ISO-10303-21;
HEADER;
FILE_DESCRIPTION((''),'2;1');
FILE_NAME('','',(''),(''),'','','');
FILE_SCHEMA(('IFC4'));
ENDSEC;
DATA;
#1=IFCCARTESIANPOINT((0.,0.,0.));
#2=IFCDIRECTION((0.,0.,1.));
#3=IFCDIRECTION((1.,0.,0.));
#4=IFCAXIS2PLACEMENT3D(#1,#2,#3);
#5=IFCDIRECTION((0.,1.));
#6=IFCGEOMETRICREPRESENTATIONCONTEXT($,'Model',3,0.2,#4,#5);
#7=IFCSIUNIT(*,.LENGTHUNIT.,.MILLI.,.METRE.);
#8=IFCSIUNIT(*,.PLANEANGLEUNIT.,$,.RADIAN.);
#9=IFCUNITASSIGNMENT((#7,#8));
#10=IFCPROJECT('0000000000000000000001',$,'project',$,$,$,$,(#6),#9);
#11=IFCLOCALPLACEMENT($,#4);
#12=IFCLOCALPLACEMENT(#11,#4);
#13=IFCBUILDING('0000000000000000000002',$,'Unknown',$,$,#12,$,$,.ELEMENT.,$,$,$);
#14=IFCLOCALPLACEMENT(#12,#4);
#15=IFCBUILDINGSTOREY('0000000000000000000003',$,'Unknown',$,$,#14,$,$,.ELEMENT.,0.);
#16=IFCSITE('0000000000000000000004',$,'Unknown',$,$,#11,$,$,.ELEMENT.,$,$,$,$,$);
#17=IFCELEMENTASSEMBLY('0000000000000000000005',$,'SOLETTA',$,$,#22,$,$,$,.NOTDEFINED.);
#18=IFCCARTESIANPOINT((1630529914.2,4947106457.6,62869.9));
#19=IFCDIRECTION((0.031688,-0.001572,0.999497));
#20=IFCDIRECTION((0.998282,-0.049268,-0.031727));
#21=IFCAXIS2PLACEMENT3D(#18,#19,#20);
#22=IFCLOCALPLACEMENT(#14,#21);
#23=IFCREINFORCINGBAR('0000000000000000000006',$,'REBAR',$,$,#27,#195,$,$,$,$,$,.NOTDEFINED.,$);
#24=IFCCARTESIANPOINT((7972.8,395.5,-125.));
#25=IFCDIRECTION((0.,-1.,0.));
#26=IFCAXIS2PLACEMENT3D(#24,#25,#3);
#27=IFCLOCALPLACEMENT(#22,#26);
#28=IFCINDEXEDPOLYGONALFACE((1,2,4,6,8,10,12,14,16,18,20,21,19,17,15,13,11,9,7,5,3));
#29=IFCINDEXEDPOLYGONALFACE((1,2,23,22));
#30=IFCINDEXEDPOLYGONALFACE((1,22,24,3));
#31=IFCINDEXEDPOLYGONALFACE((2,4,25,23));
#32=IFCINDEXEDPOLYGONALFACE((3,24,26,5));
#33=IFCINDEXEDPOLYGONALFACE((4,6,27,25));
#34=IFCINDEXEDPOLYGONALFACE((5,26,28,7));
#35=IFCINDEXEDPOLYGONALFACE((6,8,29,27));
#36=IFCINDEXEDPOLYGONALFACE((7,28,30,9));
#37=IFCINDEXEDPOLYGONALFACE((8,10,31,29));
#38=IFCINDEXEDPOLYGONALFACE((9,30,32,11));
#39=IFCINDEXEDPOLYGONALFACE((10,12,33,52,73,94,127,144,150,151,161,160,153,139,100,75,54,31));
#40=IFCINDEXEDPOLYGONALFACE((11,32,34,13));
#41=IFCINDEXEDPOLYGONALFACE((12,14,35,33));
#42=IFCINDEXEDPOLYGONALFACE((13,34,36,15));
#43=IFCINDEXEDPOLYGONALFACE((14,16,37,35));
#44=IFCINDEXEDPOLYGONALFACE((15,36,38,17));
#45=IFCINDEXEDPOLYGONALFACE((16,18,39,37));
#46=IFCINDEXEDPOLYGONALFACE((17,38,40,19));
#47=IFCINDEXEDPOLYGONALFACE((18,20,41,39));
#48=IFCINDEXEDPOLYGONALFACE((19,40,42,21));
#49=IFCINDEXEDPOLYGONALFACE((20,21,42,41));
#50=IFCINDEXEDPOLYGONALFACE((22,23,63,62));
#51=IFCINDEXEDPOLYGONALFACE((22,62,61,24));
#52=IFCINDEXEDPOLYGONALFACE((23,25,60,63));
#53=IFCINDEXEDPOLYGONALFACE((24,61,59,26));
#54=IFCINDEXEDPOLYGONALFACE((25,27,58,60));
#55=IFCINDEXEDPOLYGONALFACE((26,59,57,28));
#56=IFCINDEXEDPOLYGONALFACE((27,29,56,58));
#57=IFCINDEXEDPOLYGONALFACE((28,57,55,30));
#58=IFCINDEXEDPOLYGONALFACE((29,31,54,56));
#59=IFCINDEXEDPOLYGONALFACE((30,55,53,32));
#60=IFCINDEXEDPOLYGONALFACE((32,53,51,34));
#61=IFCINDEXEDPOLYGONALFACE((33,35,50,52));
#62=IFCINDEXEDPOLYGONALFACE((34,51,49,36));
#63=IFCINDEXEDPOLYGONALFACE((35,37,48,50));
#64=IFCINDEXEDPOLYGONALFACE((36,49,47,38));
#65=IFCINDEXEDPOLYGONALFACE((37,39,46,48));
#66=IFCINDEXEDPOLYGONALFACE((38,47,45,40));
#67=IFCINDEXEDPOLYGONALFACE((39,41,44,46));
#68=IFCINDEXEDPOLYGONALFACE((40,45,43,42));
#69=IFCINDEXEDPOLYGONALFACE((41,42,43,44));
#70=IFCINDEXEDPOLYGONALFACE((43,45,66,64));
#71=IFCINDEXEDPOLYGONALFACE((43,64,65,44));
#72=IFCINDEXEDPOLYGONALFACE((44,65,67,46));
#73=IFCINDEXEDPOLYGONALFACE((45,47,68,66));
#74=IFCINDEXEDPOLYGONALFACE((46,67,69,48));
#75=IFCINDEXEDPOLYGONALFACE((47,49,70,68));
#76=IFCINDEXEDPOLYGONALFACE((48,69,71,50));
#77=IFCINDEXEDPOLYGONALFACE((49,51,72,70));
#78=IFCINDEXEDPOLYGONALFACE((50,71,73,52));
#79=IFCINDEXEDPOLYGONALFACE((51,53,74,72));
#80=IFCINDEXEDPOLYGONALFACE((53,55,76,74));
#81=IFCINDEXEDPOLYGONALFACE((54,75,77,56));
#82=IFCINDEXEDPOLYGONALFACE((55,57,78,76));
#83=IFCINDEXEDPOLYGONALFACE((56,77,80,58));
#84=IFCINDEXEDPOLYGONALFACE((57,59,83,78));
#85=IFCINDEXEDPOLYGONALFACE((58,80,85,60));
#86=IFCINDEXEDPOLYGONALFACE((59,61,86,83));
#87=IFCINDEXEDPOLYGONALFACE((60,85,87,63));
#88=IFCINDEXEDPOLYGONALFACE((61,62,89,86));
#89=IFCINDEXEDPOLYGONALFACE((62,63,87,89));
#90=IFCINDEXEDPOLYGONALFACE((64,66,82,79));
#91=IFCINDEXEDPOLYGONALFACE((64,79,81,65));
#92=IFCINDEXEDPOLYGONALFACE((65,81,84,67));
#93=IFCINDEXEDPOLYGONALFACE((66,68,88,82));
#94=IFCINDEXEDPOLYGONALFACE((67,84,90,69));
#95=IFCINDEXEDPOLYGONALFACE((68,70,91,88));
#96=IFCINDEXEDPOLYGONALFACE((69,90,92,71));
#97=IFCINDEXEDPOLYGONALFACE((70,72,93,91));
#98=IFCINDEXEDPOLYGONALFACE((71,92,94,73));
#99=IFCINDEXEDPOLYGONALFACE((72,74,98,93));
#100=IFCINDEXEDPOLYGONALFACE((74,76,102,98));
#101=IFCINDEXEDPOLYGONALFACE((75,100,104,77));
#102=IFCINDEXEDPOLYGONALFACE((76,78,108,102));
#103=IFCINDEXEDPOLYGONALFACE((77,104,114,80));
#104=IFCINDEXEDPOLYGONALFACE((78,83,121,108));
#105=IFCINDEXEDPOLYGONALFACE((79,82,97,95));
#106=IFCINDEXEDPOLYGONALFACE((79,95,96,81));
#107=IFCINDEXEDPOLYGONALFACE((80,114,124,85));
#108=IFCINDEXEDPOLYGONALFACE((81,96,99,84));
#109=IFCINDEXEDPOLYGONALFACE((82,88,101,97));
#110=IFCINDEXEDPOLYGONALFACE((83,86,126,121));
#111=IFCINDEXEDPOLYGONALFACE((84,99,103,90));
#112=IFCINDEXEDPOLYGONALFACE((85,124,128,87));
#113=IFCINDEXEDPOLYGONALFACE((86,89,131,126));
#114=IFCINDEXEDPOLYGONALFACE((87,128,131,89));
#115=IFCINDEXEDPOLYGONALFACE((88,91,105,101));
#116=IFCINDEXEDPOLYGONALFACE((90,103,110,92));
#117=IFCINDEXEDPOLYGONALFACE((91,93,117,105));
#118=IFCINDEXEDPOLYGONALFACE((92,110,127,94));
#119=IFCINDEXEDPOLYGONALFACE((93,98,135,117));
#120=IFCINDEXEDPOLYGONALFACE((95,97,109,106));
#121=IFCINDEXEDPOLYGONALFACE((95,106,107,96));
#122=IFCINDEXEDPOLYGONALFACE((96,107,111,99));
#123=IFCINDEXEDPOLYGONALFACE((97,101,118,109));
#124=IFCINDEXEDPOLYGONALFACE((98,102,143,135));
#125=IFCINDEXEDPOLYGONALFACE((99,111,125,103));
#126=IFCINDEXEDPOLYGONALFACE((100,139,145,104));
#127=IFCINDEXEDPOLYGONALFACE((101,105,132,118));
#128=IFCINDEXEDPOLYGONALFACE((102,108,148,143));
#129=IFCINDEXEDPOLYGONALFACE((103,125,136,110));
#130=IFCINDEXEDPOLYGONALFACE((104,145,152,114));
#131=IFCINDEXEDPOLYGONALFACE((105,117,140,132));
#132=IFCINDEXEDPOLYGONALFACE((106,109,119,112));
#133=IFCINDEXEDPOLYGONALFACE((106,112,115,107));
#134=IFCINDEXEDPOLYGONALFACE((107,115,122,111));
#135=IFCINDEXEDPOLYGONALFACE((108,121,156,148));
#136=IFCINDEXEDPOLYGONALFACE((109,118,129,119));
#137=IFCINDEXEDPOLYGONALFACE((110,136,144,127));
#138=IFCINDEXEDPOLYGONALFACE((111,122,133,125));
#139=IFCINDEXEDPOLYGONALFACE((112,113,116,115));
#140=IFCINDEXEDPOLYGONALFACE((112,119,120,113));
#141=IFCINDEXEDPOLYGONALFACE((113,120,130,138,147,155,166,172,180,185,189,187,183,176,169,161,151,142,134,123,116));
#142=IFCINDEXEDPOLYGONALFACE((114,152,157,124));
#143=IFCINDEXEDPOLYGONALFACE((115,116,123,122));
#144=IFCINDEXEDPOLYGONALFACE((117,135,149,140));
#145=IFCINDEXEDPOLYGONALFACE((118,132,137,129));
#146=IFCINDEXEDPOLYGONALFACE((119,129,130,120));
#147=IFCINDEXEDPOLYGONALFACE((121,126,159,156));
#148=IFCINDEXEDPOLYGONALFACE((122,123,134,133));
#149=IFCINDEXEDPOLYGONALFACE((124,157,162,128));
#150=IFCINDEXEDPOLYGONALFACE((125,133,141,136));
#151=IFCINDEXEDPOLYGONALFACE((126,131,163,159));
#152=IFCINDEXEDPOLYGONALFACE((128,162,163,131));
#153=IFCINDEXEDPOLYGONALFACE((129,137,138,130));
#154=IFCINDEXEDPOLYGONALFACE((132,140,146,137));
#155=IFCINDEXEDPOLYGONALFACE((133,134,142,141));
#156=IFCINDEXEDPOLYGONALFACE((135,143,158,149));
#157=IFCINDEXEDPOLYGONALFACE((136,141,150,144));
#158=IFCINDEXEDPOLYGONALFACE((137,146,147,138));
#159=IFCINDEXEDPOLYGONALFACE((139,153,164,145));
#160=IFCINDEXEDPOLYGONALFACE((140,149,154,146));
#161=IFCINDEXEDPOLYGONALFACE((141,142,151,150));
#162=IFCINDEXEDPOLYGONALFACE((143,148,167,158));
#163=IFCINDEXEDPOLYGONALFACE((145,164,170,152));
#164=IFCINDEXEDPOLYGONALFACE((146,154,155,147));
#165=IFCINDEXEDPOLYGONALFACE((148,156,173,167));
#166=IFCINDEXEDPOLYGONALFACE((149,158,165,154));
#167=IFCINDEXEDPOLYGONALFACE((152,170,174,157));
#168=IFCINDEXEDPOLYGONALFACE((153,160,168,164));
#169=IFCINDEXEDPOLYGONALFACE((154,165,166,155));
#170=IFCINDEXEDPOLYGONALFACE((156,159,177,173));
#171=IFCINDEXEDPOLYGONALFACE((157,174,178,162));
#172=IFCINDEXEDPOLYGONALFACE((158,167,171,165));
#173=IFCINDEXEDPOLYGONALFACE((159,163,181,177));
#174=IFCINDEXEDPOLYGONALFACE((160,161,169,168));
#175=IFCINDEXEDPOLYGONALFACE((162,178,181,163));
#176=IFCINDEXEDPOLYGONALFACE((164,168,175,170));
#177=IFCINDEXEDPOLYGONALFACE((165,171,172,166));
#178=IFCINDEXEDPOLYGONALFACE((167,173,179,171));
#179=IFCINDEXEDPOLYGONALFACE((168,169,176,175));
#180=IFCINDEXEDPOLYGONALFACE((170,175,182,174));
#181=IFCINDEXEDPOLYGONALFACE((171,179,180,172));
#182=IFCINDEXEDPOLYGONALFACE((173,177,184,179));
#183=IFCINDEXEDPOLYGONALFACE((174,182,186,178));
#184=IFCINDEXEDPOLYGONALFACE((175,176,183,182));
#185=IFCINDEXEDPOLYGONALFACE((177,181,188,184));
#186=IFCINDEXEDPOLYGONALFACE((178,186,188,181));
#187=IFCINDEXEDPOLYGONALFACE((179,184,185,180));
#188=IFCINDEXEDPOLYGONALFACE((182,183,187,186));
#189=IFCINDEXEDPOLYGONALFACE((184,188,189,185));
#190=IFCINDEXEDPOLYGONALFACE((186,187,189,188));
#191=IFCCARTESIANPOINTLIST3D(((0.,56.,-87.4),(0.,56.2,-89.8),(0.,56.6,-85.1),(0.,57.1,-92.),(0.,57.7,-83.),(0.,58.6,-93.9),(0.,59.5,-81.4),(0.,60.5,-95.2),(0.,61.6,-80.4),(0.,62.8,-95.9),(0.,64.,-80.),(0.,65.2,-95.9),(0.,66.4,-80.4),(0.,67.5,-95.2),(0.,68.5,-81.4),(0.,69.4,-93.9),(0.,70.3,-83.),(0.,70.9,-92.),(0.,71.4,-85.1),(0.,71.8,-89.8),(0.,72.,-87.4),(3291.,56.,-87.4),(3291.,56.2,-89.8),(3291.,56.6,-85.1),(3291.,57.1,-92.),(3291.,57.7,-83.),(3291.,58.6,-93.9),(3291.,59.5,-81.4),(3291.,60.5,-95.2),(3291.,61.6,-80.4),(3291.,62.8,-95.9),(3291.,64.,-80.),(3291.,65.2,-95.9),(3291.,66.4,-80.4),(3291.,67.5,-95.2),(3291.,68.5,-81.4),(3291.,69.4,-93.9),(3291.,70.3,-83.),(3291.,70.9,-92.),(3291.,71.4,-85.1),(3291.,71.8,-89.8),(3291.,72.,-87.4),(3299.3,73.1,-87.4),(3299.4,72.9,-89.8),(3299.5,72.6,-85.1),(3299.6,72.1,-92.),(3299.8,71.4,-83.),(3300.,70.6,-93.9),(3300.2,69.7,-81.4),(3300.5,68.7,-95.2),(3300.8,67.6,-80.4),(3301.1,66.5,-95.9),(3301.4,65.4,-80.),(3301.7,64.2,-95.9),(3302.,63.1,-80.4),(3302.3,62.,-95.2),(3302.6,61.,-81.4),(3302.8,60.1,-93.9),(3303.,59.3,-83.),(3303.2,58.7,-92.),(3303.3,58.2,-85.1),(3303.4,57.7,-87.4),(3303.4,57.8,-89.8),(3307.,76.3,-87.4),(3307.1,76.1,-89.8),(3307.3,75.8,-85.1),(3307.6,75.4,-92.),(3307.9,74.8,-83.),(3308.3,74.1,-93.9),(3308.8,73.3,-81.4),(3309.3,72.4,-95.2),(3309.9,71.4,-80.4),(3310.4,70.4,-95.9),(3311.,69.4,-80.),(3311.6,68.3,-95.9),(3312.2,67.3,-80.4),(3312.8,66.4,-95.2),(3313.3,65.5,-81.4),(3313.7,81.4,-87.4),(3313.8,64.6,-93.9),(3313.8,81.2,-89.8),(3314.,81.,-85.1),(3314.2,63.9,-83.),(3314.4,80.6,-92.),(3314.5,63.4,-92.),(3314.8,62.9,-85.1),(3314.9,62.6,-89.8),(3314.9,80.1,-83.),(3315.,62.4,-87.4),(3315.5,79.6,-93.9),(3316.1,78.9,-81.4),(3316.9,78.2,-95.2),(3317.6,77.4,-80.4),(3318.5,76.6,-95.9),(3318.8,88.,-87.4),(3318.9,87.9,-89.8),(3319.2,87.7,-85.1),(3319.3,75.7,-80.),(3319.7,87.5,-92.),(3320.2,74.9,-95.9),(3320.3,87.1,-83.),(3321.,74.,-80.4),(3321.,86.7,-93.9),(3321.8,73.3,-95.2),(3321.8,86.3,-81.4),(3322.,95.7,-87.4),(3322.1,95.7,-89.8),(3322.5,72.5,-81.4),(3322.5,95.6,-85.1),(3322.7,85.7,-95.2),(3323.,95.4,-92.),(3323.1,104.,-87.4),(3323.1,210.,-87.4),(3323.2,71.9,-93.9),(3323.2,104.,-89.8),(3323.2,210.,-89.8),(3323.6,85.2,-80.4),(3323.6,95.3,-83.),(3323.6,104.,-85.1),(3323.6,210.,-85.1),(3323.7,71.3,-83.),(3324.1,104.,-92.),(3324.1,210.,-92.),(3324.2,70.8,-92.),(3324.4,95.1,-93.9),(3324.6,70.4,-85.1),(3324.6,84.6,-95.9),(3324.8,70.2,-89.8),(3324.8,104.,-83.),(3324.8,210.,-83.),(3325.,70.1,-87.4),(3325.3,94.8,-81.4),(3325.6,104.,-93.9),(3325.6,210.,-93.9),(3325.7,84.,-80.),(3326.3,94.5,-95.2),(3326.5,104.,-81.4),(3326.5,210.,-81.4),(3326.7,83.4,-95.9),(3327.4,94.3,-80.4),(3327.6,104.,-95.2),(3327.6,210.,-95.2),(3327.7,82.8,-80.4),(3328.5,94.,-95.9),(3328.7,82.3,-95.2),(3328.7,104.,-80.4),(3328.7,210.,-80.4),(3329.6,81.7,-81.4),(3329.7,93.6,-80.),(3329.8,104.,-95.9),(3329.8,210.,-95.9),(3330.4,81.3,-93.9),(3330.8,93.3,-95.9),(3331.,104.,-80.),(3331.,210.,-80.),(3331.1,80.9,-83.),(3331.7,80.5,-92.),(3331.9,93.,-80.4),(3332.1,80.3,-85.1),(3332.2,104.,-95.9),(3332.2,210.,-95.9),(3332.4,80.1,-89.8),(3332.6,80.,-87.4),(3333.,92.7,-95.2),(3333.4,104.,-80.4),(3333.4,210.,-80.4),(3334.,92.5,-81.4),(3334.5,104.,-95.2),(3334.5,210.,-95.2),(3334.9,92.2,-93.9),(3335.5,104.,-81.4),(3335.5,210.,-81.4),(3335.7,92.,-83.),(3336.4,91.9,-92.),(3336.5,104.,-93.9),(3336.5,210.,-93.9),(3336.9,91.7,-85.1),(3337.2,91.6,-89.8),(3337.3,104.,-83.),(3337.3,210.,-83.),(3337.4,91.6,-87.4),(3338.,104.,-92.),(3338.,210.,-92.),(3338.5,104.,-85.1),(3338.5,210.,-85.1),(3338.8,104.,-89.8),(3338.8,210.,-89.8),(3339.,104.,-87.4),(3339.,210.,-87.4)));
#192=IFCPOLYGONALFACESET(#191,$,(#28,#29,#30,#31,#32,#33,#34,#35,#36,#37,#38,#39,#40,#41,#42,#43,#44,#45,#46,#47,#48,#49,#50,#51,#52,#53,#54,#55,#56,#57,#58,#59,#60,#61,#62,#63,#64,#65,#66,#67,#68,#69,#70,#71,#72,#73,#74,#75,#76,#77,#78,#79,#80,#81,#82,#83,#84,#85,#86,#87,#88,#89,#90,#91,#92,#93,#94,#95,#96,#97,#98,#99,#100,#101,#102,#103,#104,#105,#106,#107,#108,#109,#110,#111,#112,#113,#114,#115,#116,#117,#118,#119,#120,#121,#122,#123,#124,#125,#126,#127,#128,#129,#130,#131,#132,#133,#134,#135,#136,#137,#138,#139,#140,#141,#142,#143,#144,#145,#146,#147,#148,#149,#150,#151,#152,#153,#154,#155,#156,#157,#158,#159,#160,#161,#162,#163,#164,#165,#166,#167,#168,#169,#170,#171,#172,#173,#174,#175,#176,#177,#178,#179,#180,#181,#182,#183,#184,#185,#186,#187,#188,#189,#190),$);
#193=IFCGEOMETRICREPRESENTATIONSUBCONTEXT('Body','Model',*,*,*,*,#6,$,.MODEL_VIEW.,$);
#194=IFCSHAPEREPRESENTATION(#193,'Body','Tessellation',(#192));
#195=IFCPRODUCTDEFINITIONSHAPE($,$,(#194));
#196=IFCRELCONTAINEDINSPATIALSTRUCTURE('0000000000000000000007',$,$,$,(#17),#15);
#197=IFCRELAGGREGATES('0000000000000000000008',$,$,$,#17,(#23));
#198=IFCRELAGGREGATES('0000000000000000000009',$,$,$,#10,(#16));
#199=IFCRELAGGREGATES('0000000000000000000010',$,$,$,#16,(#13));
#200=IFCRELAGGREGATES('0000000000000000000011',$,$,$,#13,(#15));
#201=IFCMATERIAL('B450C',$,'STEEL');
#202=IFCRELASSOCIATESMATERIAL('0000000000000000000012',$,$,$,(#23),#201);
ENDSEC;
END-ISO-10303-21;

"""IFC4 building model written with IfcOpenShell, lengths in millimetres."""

from ifc_helpers import new_model, entity, si_unit, direction, frame, origin_with_axes, place, context, subcontext, project, spatial, material, element, aggregate, save


model = new_model("IFC4")

# Units and contexts
model_context = context("Model", 3, precision=0.2, world=origin_with_axes(), true_north=direction((0.0, 1.0)))
body_context = subcontext(model_context, "Body", "Model", "MODEL_VIEW")
ifc_project = project(units=[si_unit("LENGTHUNIT", "METRE", prefix="MILLI"), si_unit("PLANEANGLEUNIT", "RADIAN")], contexts=[model_context])

# Site, building, storey
site_placement = place(None, origin_with_axes())
site = spatial("IfcSite", under=ifc_project, at=site_placement, Name="Unknown", CompositionType="ELEMENT")
building_placement = place(site_placement, origin_with_axes())
building = spatial("IfcBuilding", under=site, at=building_placement, Name="Unknown", CompositionType="ELEMENT")
storey_placement = place(building_placement, origin_with_axes())
storey = spatial("IfcBuildingStorey", under=building, at=storey_placement, Name="Unknown", CompositionType="ELEMENT", Elevation=0.0)

# Element assembly, reinforcing bar
ifc_material = material(Name="B450C", Category="STEEL")
assembly_1_placement = place(storey_placement, frame((1630529914.2, 4947106457.6, 62869.9), z_axis=(0.031688, -0.001572, 0.999497), x_axis=(0.998282, -0.049268, -0.031727)))
assembly_1 = element("IfcElementAssembly", 1, at=assembly_1_placement, inside=storey, Name="SOLETTA", PredefinedType="NOTDEFINED")
reinforcing_bar_1_placement = place(assembly_1_placement, frame((7972.8, 395.5, -125.0), z_axis=(0.0, -1.0, 0.0), x_axis=(1.0, 0.0, 0.0)))
reinforcing_bar_1 = element("IfcReinforcingBar", 2, at=reinforcing_bar_1_placement, material=ifc_material, Name="REBAR", PredefinedType="NOTDEFINED", context=body_context, shape_type="AdvancedSweptSolid", body=[
    entity("IfcSweptDiskSolid", entity("IfcIndexedPolyCurve", entity("IfcCartesianPointList3D", [[0.0, 64.0, -88.0], [3291.0, 64.0, -88.0], [3319.3, 75.7, -88.0], [3331.0, 104.0, -88.0], [3331.0, 210.0, -88.0]]), [entity("IfcLineIndex", [1, 2]), entity("IfcArcIndex", [2, 3, 4]), entity("IfcLineIndex", [4, 5])]), 8.0),
])
aggregate(assembly_1, [reinforcing_bar_1])

save(model, "model.ifc")
